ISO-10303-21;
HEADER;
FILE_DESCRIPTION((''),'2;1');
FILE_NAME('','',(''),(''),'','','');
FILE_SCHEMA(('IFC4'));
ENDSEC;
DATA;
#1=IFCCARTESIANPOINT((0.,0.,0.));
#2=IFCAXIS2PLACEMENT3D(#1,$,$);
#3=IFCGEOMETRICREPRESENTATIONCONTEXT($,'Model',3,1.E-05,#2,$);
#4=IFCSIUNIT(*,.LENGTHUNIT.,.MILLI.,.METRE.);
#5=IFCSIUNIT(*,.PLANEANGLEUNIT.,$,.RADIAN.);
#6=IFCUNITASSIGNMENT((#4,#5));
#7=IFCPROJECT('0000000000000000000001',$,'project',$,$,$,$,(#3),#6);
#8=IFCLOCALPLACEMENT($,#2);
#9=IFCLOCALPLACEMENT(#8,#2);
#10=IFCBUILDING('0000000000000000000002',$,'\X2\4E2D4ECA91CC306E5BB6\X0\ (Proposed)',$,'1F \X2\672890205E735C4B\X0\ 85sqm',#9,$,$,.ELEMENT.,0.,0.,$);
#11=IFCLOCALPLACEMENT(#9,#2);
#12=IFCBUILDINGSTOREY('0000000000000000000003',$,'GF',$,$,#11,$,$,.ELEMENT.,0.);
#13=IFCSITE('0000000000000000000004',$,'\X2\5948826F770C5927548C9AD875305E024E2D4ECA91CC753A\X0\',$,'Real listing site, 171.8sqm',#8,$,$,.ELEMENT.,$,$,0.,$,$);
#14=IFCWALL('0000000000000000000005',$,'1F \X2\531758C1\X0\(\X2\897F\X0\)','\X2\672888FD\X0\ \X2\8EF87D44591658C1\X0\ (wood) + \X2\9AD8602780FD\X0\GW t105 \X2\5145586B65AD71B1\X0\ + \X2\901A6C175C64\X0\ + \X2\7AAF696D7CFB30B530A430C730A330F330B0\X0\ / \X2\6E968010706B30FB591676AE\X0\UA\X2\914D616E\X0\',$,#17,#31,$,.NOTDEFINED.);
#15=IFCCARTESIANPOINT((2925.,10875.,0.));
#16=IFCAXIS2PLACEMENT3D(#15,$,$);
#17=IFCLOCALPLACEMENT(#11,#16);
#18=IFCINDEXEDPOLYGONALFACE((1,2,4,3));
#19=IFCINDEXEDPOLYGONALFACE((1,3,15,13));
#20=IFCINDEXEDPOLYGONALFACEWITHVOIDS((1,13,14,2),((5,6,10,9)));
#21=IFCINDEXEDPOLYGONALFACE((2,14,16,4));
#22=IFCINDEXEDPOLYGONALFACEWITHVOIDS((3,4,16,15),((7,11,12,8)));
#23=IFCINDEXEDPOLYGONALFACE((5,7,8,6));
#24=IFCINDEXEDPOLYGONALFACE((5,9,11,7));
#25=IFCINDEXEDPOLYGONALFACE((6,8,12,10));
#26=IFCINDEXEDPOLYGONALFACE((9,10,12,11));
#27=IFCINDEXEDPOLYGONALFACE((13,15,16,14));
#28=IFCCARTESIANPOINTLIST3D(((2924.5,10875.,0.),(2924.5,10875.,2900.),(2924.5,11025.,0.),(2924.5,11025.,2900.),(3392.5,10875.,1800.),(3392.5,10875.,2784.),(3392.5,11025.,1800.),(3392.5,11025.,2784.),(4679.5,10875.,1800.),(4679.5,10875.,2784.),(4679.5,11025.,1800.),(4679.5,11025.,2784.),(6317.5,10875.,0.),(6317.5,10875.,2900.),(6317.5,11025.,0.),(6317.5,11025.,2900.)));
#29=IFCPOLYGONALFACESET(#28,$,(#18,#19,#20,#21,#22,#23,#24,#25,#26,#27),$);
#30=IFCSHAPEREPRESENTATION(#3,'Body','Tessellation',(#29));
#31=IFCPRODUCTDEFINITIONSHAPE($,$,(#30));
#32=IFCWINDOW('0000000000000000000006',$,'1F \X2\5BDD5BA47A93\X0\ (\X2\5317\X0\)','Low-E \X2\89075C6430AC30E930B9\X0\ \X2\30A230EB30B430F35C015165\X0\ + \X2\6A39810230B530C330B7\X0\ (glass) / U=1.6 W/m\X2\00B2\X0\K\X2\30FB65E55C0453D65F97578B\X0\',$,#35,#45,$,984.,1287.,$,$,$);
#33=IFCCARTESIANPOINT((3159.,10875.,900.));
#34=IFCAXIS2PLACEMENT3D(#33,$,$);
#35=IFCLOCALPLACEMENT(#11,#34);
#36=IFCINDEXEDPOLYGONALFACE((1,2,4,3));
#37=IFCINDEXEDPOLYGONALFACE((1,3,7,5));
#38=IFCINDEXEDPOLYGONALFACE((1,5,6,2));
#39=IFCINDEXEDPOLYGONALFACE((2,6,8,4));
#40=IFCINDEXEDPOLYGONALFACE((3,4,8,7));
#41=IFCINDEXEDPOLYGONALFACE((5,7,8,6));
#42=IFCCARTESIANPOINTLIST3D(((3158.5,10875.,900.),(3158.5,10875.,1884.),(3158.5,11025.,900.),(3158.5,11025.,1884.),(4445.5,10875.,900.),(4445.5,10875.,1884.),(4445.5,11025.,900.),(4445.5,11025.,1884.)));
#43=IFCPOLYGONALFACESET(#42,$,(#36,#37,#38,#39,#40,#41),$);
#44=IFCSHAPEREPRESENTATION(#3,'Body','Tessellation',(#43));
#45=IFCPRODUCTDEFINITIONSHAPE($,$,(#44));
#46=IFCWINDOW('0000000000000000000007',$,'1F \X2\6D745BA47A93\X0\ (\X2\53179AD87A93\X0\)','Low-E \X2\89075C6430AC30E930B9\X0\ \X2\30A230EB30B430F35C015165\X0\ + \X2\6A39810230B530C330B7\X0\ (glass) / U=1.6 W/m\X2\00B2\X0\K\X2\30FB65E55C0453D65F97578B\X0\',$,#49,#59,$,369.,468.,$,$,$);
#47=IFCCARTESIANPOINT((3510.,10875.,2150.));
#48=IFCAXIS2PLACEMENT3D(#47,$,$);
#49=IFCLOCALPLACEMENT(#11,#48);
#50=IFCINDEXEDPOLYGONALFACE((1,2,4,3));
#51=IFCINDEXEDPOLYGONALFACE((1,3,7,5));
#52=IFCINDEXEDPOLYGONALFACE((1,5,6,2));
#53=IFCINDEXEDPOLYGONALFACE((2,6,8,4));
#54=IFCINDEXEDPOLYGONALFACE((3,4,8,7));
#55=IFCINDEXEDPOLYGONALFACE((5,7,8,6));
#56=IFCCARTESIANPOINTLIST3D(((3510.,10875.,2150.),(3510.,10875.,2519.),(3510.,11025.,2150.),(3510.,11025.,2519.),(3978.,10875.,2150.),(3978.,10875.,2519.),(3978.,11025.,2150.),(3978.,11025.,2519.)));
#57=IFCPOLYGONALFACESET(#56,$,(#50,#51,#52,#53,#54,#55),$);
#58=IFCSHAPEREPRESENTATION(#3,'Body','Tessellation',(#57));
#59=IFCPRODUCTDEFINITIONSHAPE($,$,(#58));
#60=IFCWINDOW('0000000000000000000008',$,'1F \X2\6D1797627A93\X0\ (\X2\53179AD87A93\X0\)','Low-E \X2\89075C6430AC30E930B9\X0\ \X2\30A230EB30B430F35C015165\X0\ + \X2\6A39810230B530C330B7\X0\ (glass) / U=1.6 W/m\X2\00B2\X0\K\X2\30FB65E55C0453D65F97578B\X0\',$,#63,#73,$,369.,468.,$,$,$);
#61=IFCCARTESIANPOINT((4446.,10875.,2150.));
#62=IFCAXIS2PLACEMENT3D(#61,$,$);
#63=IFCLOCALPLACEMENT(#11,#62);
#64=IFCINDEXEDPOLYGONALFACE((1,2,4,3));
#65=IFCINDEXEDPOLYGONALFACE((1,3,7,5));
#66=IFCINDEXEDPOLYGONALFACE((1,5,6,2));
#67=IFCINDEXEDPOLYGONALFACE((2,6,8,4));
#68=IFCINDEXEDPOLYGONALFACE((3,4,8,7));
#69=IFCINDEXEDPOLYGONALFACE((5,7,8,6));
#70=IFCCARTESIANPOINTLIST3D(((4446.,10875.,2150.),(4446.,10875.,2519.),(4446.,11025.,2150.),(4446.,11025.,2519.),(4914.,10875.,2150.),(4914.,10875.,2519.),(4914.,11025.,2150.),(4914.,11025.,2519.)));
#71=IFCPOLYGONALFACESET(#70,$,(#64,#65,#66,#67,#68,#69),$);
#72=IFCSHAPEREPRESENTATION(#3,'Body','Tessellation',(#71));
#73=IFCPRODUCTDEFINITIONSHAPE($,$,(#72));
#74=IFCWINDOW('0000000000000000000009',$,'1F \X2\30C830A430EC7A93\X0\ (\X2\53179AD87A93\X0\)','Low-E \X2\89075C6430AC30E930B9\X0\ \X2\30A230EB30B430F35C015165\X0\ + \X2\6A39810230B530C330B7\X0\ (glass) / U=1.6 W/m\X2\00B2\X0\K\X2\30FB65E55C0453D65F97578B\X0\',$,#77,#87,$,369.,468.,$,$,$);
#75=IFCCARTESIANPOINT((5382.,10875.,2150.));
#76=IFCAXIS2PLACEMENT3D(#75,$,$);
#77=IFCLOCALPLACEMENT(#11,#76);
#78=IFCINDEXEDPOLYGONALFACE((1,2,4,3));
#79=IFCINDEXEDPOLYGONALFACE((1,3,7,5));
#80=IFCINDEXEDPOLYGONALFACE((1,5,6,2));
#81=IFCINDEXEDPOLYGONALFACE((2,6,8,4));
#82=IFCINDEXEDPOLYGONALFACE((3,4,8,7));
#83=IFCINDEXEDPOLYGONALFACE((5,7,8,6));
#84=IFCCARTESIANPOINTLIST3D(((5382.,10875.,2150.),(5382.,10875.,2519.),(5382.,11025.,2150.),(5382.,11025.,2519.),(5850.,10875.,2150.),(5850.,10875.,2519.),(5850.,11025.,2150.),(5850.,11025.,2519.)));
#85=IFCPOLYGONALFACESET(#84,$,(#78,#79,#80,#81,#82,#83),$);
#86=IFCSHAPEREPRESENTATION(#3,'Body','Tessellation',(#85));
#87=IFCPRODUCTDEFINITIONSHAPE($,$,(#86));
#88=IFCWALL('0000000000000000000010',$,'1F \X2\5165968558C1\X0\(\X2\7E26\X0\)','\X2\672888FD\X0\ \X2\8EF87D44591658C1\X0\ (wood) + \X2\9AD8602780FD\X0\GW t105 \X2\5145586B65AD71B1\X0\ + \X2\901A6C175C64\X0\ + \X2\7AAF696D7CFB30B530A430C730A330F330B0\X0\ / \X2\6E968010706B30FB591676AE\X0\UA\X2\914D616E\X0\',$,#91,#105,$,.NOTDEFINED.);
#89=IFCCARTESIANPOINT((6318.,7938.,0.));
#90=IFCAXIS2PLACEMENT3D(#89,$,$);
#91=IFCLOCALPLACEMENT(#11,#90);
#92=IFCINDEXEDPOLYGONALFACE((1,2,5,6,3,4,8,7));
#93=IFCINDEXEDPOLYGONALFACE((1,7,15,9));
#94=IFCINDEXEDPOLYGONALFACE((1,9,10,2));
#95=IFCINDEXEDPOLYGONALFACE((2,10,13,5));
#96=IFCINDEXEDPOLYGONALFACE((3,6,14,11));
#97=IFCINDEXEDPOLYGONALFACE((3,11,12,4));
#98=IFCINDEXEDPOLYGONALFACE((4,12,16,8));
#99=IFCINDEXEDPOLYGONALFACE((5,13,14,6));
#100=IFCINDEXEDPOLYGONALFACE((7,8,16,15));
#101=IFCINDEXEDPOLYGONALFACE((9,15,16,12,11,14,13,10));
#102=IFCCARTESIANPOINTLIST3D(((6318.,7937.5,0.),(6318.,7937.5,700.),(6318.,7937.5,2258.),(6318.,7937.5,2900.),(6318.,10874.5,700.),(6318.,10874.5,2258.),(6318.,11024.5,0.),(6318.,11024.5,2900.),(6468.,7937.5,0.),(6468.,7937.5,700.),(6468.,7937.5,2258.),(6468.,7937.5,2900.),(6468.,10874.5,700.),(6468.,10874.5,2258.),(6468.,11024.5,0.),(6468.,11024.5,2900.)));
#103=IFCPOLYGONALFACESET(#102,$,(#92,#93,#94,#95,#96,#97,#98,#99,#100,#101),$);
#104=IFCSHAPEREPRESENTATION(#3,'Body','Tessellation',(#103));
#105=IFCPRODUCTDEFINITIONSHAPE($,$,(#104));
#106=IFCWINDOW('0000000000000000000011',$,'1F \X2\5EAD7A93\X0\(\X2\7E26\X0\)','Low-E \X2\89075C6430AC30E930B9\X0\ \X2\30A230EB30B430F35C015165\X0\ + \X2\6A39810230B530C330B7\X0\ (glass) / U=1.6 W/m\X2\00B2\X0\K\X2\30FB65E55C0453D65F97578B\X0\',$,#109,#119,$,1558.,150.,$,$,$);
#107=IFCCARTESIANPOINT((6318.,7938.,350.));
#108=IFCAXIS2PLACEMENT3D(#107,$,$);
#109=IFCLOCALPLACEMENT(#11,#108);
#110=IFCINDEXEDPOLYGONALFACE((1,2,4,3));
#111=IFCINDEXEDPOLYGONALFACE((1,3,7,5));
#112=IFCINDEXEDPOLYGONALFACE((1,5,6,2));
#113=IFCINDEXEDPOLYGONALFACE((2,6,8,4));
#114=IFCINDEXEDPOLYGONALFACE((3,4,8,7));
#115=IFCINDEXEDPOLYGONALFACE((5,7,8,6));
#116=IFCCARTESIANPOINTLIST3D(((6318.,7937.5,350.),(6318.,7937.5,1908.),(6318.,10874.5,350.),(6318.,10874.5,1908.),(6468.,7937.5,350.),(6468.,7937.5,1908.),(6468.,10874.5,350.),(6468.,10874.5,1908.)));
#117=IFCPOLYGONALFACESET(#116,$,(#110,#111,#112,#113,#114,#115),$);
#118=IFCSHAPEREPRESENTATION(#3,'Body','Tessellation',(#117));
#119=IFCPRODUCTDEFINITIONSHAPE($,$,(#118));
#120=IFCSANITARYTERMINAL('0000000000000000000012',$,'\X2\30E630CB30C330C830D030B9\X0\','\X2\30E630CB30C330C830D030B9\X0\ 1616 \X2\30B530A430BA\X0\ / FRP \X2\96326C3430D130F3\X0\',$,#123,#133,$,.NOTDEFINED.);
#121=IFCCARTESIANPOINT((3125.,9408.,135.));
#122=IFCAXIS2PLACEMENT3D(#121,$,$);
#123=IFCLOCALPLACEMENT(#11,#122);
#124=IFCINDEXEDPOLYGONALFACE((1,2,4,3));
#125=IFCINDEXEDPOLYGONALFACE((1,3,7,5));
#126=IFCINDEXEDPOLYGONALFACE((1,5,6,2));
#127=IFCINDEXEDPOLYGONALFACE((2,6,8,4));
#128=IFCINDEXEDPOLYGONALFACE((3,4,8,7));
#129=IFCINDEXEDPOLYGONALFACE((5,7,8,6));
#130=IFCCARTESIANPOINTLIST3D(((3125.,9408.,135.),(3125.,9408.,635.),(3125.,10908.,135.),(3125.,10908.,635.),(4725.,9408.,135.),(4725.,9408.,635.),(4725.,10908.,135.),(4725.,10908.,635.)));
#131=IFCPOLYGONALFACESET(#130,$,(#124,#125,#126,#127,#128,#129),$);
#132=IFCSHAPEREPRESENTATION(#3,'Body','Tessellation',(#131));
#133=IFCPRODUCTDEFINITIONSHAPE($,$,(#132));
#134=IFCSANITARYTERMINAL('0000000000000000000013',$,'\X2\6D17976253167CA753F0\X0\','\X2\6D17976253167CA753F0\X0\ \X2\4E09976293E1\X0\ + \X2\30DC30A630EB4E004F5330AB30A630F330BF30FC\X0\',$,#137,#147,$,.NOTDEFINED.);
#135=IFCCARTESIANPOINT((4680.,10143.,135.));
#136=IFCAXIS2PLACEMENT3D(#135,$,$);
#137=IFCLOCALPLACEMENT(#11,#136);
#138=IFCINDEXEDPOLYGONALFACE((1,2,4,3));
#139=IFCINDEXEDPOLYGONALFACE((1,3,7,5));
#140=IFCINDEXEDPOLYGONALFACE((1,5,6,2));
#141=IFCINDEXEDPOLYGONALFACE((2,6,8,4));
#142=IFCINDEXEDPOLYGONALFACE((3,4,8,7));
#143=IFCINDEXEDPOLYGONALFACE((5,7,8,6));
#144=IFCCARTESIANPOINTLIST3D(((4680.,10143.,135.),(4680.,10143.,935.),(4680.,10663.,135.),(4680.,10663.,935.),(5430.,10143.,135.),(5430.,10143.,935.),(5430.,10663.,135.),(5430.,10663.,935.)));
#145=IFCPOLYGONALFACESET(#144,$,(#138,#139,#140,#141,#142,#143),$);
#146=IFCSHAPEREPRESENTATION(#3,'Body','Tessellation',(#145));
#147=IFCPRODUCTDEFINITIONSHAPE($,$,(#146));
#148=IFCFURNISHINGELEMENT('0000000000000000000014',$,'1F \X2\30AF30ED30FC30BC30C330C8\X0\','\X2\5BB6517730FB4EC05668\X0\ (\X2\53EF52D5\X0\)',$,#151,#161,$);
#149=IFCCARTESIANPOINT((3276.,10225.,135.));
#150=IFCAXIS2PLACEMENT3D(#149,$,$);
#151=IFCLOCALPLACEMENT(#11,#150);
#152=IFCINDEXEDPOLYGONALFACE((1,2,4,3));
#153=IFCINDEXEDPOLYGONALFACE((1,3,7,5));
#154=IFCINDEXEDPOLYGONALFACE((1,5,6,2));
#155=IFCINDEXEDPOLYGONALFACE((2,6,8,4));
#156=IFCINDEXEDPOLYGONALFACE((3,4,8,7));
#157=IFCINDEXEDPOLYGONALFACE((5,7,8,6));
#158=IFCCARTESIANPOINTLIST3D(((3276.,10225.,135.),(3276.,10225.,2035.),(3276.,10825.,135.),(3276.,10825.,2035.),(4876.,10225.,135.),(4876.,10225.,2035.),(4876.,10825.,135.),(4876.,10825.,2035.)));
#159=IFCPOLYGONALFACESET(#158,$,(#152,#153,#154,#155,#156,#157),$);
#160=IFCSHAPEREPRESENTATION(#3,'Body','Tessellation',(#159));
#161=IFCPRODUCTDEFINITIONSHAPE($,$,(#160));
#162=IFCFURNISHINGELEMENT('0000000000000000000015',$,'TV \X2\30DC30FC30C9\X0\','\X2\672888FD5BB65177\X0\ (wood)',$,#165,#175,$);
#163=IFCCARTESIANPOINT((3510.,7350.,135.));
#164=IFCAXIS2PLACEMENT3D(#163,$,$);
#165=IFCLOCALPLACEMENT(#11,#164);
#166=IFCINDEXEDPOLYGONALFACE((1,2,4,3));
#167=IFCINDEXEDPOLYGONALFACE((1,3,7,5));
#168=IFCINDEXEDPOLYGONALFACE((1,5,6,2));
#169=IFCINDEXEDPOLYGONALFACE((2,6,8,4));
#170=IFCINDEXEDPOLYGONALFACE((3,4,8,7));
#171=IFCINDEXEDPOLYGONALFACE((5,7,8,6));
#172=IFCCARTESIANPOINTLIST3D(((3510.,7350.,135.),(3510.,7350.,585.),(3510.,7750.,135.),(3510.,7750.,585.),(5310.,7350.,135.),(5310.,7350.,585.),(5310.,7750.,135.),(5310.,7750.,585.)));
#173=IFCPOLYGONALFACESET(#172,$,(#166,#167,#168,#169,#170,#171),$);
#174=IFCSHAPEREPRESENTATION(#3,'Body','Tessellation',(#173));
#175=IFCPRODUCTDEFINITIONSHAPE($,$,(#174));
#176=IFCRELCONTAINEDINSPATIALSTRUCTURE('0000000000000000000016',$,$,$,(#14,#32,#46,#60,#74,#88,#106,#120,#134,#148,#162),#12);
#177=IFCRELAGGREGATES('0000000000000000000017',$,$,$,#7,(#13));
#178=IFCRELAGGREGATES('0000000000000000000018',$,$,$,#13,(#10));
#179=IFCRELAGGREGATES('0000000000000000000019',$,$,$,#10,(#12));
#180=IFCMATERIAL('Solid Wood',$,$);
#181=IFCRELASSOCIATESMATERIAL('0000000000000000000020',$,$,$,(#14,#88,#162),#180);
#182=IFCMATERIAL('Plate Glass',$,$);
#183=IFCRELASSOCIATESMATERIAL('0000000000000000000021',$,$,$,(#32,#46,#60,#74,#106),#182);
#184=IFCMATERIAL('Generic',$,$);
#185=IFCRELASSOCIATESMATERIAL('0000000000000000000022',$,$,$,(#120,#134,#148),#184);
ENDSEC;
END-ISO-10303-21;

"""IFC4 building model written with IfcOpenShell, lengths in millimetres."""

from ifc_helpers import new_model, si_unit, frame, frame_2d, origin, place, context, project, spatial, rectangle, extrude, material, element, fill, save


model = new_model("IFC4")

# Units and contexts
model_context = context("Model", 3, precision=1e-05, world=origin())
ifc_project = project(units=[si_unit("LENGTHUNIT", "METRE", prefix="MILLI"), si_unit("PLANEANGLEUNIT", "RADIAN")], contexts=[model_context])

# Site, building, storey
site_placement = place(None, origin())
site = spatial("IfcSite", under=ifc_project, at=site_placement, Name="奈良県大和高田市中今里町", ObjectType="Real listing site, 171.8sqm", CompositionType="ELEMENT", RefElevation=0.0)
building_placement = place(site_placement, origin())
building = spatial("IfcBuilding", under=site, at=building_placement, Name="中今里の家 (Proposed)", ObjectType="1F 木造平屋 85sqm", CompositionType="ELEMENT", ElevationOfRefHeight=0.0, ElevationOfTerrain=0.0)
storey_placement = place(building_placement, origin())
storey = spatial("IfcBuildingStorey", under=building, at=storey_placement, Name="GF", CompositionType="ELEMENT", Elevation=0.0)

# Shared definitions
ifc_material_1 = material(Name="Solid Wood")

# Wall, openings, windows
wall_1_placement = place(storey_placement, frame((2925.0, 10875.0, 0.0)))
wall_1 = element("IfcWall", 1, at=wall_1_placement, inside=storey, material=ifc_material_1, Name="1F 北壁(西)", Description="木製 軸組外壁 (wood) + 高性能GW t105 充填断熱 + 通気層 + 窯業系サイディング / 準耐火・外皮UA配慮", PredefinedType="NOTDEFINED", context=model_context, shape_type="SweptSolid", body=[
    extrude(rectangle(XDim=3393.0, YDim=150.0, at=frame_2d((1696.0, 75.0))), frame((2925.0, 10875.0, 0.0)), (0.0, 0.0, 1.0), 2900.0),
])
opening_1_placement = place(storey_placement, frame((3159.0, 10875.0, 900.0)))
opening_1 = element("IfcOpeningElement", 2, at=opening_1_placement, cuts=wall_1, PredefinedType="NOTDEFINED", context=model_context, shape_type="SweptSolid", body=[
    extrude(rectangle(XDim=1287.0, YDim=150.0, at=frame_2d((643.0, 75.0))), frame((3159.0, 10875.0, 900.0)), (0.0, 0.0, 1.0), 984.0),
])
opening_2_placement = place(storey_placement, frame((3510.0, 10875.0, 2150.0)))
opening_2 = element("IfcOpeningElement", 3, at=opening_2_placement, cuts=wall_1, PredefinedType="NOTDEFINED", context=model_context, shape_type="SweptSolid", body=[
    extrude(rectangle(XDim=468.0, YDim=150.0, at=frame_2d((234.0, 75.0))), frame((3510.0, 10875.0, 2150.0)), (0.0, 0.0, 1.0), 369.0),
])
opening_3_placement = place(storey_placement, frame((4446.0, 10875.0, 2150.0)))
opening_3 = element("IfcOpeningElement", 4, at=opening_3_placement, cuts=wall_1, PredefinedType="NOTDEFINED", context=model_context, shape_type="SweptSolid", body=[
    extrude(rectangle(XDim=468.0, YDim=150.0, at=frame_2d((234.0, 75.0))), frame((4446.0, 10875.0, 2150.0)), (0.0, 0.0, 1.0), 369.0),
])
opening_4_placement = place(storey_placement, frame((5382.0, 10875.0, 2150.0)))
opening_4 = element("IfcOpeningElement", 5, at=opening_4_placement, cuts=wall_1, PredefinedType="NOTDEFINED", context=model_context, shape_type="SweptSolid", body=[
    extrude(rectangle(XDim=468.0, YDim=150.0, at=frame_2d((234.0, 75.0))), frame((5382.0, 10875.0, 2150.0)), (0.0, 0.0, 1.0), 369.0),
])
ifc_material_2 = material(Name="Plate Glass")
window_1_placement = place(storey_placement, frame((3159.0, 10875.0, 900.0)))
window_1 = element("IfcWindow", 6, at=window_1_placement, inside=storey, material=ifc_material_2, Name="1F 寝室窓 (北)", Description="Low-E 複層ガラス アルゴン封入 + 樹脂サッシ (glass) / U=1.6 W/m²K・日射取得型", OverallHeight=984.0, OverallWidth=1287.0, context=model_context, shape_type="SweptSolid", body=[
    extrude(rectangle(XDim=1287.0, YDim=150.0, at=frame_2d((643.0, 75.0))), frame((3159.0, 10875.0, 900.0)), (0.0, 0.0, 1.0), 984.0),
])
fill(opening_1, window_1)
window_2_placement = place(storey_placement, frame((3510.0, 10875.0, 2150.0)))
window_2 = element("IfcWindow", 7, at=window_2_placement, inside=storey, material=ifc_material_2, Name="1F 浴室窓 (北高窓)", Description="Low-E 複層ガラス アルゴン封入 + 樹脂サッシ (glass) / U=1.6 W/m²K・日射取得型", OverallHeight=369.0, OverallWidth=468.0, context=model_context, shape_type="SweptSolid", body=[
    extrude(rectangle(XDim=468.0, YDim=150.0, at=frame_2d((234.0, 75.0))), frame((3510.0, 10875.0, 2150.0)), (0.0, 0.0, 1.0), 369.0),
])
fill(opening_2, window_2)
window_3_placement = place(storey_placement, frame((4446.0, 10875.0, 2150.0)))
window_3 = element("IfcWindow", 8, at=window_3_placement, inside=storey, material=ifc_material_2, Name="1F 洗面窓 (北高窓)", Description="Low-E 複層ガラス アルゴン封入 + 樹脂サッシ (glass) / U=1.6 W/m²K・日射取得型", OverallHeight=369.0, OverallWidth=468.0, context=model_context, shape_type="SweptSolid", body=[
    extrude(rectangle(XDim=468.0, YDim=150.0, at=frame_2d((234.0, 75.0))), frame((4446.0, 10875.0, 2150.0)), (0.0, 0.0, 1.0), 369.0),
])
fill(opening_3, window_3)
window_4_placement = place(storey_placement, frame((5382.0, 10875.0, 2150.0)))
window_4 = element("IfcWindow", 9, at=window_4_placement, inside=storey, material=ifc_material_2, Name="1F トイレ窓 (北高窓)", Description="Low-E 複層ガラス アルゴン封入 + 樹脂サッシ (glass) / U=1.6 W/m²K・日射取得型", OverallHeight=369.0, OverallWidth=468.0, context=model_context, shape_type="SweptSolid", body=[
    extrude(rectangle(XDim=468.0, YDim=150.0, at=frame_2d((234.0, 75.0))), frame((5382.0, 10875.0, 2150.0)), (0.0, 0.0, 1.0), 369.0),
])
fill(opening_4, window_4)

# Wall, opening, window
wall_2_placement = place(storey_placement, frame((6318.0, 7938.0, 0.0)))
wall_2 = element("IfcWall", 10, at=wall_2_placement, inside=storey, material=ifc_material_1, Name="1F 入隅壁(縦)", Description="木製 軸組外壁 (wood) + 高性能GW t105 充填断熱 + 通気層 + 窯業系サイディング / 準耐火・外皮UA配慮", PredefinedType="NOTDEFINED", context=model_context, shape_type="SweptSolid", body=[
    extrude(rectangle(XDim=150.0, YDim=3087.0, at=frame_2d((75.0, 1543.0))), frame((6318.0, 7938.0, 0.0)), (0.0, 0.0, 1.0), 2900.0),
])
opening_5_placement = place(storey_placement, frame((6318.0, 7938.0, 350.0)))
opening_5 = element("IfcOpeningElement", 11, at=opening_5_placement, cuts=wall_2, PredefinedType="NOTDEFINED", context=model_context, shape_type="SweptSolid", body=[
    extrude(rectangle(XDim=150.0, YDim=2937.0, at=frame_2d((75.0, 1468.0))), frame((6318.0, 7938.0, 350.0)), (0.0, 0.0, 1.0), 1558.0),
])
window_5_placement = place(storey_placement, frame((6318.0, 7938.0, 350.0)))
window_5 = element("IfcWindow", 12, at=window_5_placement, inside=storey, material=ifc_material_2, Name="1F 庭窓(縦)", Description="Low-E 複層ガラス アルゴン封入 + 樹脂サッシ (glass) / U=1.6 W/m²K・日射取得型", OverallHeight=1558.0, OverallWidth=150.0, context=model_context, shape_type="SweptSolid", body=[
    extrude(rectangle(XDim=150.0, YDim=2937.0, at=frame_2d((75.0, 1468.0))), frame((6318.0, 7938.0, 350.0)), (0.0, 0.0, 1.0), 1558.0),
])
fill(opening_5, window_5)

# Shared definitions
ifc_material_3 = material(Name="Generic")

# Sanitary terminals
sanitary_terminal_1_placement = place(storey_placement, frame((3125.0, 9408.0, 135.0)))
element("IfcSanitaryTerminal", 13, at=sanitary_terminal_1_placement, inside=storey, material=ifc_material_3, Name="ユニットバス", Description="ユニットバス 1616 サイズ / FRP 防水パン", PredefinedType="NOTDEFINED", context=model_context, shape_type="SweptSolid", body=[
    extrude(rectangle(XDim=1600.0, YDim=1500.0, at=frame_2d((800.0, 750.0))), frame((3125.0, 9408.0, 135.0)), (0.0, 0.0, 1.0), 500.0),
])
sanitary_terminal_2_placement = place(storey_placement, frame((4680.0, 10143.0, 135.0)))
element("IfcSanitaryTerminal", 14, at=sanitary_terminal_2_placement, inside=storey, material=ifc_material_3, Name="洗面化粧台", Description="洗面化粧台 三面鏡 + ボウル一体カウンター", PredefinedType="NOTDEFINED", context=model_context, shape_type="SweptSolid", body=[
    extrude(rectangle(XDim=750.0, YDim=520.0, at=frame_2d((375.0, 260.0))), frame((4680.0, 10143.0, 135.0)), (0.0, 0.0, 1.0), 800.0),
])

# Furnishing elements
furnishing_1_placement = place(storey_placement, frame((3276.0, 10225.0, 135.0)))
element("IfcFurnishingElement", 15, at=furnishing_1_placement, inside=storey, material=ifc_material_3, Name="1F クローゼット", Description="家具・什器 (可動)", context=model_context, shape_type="SweptSolid", body=[
    extrude(rectangle(XDim=1600.0, YDim=600.0, at=frame_2d((800.0, 300.0))), frame((3276.0, 10225.0, 135.0)), (0.0, 0.0, 1.0), 1900.0),
])
furnishing_2_placement = place(storey_placement, frame((3510.0, 7350.0, 135.0)))
element("IfcFurnishingElement", 16, at=furnishing_2_placement, inside=storey, material=ifc_material_1, Name="TV ボード", Description="木製家具 (wood)", context=model_context, shape_type="SweptSolid", body=[
    extrude(rectangle(XDim=1800.0, YDim=400.0, at=frame_2d((900.0, 200.0))), frame((3510.0, 7350.0, 135.0)), (0.0, 0.0, 1.0), 450.0),
])

save(model, "model.ifc")
